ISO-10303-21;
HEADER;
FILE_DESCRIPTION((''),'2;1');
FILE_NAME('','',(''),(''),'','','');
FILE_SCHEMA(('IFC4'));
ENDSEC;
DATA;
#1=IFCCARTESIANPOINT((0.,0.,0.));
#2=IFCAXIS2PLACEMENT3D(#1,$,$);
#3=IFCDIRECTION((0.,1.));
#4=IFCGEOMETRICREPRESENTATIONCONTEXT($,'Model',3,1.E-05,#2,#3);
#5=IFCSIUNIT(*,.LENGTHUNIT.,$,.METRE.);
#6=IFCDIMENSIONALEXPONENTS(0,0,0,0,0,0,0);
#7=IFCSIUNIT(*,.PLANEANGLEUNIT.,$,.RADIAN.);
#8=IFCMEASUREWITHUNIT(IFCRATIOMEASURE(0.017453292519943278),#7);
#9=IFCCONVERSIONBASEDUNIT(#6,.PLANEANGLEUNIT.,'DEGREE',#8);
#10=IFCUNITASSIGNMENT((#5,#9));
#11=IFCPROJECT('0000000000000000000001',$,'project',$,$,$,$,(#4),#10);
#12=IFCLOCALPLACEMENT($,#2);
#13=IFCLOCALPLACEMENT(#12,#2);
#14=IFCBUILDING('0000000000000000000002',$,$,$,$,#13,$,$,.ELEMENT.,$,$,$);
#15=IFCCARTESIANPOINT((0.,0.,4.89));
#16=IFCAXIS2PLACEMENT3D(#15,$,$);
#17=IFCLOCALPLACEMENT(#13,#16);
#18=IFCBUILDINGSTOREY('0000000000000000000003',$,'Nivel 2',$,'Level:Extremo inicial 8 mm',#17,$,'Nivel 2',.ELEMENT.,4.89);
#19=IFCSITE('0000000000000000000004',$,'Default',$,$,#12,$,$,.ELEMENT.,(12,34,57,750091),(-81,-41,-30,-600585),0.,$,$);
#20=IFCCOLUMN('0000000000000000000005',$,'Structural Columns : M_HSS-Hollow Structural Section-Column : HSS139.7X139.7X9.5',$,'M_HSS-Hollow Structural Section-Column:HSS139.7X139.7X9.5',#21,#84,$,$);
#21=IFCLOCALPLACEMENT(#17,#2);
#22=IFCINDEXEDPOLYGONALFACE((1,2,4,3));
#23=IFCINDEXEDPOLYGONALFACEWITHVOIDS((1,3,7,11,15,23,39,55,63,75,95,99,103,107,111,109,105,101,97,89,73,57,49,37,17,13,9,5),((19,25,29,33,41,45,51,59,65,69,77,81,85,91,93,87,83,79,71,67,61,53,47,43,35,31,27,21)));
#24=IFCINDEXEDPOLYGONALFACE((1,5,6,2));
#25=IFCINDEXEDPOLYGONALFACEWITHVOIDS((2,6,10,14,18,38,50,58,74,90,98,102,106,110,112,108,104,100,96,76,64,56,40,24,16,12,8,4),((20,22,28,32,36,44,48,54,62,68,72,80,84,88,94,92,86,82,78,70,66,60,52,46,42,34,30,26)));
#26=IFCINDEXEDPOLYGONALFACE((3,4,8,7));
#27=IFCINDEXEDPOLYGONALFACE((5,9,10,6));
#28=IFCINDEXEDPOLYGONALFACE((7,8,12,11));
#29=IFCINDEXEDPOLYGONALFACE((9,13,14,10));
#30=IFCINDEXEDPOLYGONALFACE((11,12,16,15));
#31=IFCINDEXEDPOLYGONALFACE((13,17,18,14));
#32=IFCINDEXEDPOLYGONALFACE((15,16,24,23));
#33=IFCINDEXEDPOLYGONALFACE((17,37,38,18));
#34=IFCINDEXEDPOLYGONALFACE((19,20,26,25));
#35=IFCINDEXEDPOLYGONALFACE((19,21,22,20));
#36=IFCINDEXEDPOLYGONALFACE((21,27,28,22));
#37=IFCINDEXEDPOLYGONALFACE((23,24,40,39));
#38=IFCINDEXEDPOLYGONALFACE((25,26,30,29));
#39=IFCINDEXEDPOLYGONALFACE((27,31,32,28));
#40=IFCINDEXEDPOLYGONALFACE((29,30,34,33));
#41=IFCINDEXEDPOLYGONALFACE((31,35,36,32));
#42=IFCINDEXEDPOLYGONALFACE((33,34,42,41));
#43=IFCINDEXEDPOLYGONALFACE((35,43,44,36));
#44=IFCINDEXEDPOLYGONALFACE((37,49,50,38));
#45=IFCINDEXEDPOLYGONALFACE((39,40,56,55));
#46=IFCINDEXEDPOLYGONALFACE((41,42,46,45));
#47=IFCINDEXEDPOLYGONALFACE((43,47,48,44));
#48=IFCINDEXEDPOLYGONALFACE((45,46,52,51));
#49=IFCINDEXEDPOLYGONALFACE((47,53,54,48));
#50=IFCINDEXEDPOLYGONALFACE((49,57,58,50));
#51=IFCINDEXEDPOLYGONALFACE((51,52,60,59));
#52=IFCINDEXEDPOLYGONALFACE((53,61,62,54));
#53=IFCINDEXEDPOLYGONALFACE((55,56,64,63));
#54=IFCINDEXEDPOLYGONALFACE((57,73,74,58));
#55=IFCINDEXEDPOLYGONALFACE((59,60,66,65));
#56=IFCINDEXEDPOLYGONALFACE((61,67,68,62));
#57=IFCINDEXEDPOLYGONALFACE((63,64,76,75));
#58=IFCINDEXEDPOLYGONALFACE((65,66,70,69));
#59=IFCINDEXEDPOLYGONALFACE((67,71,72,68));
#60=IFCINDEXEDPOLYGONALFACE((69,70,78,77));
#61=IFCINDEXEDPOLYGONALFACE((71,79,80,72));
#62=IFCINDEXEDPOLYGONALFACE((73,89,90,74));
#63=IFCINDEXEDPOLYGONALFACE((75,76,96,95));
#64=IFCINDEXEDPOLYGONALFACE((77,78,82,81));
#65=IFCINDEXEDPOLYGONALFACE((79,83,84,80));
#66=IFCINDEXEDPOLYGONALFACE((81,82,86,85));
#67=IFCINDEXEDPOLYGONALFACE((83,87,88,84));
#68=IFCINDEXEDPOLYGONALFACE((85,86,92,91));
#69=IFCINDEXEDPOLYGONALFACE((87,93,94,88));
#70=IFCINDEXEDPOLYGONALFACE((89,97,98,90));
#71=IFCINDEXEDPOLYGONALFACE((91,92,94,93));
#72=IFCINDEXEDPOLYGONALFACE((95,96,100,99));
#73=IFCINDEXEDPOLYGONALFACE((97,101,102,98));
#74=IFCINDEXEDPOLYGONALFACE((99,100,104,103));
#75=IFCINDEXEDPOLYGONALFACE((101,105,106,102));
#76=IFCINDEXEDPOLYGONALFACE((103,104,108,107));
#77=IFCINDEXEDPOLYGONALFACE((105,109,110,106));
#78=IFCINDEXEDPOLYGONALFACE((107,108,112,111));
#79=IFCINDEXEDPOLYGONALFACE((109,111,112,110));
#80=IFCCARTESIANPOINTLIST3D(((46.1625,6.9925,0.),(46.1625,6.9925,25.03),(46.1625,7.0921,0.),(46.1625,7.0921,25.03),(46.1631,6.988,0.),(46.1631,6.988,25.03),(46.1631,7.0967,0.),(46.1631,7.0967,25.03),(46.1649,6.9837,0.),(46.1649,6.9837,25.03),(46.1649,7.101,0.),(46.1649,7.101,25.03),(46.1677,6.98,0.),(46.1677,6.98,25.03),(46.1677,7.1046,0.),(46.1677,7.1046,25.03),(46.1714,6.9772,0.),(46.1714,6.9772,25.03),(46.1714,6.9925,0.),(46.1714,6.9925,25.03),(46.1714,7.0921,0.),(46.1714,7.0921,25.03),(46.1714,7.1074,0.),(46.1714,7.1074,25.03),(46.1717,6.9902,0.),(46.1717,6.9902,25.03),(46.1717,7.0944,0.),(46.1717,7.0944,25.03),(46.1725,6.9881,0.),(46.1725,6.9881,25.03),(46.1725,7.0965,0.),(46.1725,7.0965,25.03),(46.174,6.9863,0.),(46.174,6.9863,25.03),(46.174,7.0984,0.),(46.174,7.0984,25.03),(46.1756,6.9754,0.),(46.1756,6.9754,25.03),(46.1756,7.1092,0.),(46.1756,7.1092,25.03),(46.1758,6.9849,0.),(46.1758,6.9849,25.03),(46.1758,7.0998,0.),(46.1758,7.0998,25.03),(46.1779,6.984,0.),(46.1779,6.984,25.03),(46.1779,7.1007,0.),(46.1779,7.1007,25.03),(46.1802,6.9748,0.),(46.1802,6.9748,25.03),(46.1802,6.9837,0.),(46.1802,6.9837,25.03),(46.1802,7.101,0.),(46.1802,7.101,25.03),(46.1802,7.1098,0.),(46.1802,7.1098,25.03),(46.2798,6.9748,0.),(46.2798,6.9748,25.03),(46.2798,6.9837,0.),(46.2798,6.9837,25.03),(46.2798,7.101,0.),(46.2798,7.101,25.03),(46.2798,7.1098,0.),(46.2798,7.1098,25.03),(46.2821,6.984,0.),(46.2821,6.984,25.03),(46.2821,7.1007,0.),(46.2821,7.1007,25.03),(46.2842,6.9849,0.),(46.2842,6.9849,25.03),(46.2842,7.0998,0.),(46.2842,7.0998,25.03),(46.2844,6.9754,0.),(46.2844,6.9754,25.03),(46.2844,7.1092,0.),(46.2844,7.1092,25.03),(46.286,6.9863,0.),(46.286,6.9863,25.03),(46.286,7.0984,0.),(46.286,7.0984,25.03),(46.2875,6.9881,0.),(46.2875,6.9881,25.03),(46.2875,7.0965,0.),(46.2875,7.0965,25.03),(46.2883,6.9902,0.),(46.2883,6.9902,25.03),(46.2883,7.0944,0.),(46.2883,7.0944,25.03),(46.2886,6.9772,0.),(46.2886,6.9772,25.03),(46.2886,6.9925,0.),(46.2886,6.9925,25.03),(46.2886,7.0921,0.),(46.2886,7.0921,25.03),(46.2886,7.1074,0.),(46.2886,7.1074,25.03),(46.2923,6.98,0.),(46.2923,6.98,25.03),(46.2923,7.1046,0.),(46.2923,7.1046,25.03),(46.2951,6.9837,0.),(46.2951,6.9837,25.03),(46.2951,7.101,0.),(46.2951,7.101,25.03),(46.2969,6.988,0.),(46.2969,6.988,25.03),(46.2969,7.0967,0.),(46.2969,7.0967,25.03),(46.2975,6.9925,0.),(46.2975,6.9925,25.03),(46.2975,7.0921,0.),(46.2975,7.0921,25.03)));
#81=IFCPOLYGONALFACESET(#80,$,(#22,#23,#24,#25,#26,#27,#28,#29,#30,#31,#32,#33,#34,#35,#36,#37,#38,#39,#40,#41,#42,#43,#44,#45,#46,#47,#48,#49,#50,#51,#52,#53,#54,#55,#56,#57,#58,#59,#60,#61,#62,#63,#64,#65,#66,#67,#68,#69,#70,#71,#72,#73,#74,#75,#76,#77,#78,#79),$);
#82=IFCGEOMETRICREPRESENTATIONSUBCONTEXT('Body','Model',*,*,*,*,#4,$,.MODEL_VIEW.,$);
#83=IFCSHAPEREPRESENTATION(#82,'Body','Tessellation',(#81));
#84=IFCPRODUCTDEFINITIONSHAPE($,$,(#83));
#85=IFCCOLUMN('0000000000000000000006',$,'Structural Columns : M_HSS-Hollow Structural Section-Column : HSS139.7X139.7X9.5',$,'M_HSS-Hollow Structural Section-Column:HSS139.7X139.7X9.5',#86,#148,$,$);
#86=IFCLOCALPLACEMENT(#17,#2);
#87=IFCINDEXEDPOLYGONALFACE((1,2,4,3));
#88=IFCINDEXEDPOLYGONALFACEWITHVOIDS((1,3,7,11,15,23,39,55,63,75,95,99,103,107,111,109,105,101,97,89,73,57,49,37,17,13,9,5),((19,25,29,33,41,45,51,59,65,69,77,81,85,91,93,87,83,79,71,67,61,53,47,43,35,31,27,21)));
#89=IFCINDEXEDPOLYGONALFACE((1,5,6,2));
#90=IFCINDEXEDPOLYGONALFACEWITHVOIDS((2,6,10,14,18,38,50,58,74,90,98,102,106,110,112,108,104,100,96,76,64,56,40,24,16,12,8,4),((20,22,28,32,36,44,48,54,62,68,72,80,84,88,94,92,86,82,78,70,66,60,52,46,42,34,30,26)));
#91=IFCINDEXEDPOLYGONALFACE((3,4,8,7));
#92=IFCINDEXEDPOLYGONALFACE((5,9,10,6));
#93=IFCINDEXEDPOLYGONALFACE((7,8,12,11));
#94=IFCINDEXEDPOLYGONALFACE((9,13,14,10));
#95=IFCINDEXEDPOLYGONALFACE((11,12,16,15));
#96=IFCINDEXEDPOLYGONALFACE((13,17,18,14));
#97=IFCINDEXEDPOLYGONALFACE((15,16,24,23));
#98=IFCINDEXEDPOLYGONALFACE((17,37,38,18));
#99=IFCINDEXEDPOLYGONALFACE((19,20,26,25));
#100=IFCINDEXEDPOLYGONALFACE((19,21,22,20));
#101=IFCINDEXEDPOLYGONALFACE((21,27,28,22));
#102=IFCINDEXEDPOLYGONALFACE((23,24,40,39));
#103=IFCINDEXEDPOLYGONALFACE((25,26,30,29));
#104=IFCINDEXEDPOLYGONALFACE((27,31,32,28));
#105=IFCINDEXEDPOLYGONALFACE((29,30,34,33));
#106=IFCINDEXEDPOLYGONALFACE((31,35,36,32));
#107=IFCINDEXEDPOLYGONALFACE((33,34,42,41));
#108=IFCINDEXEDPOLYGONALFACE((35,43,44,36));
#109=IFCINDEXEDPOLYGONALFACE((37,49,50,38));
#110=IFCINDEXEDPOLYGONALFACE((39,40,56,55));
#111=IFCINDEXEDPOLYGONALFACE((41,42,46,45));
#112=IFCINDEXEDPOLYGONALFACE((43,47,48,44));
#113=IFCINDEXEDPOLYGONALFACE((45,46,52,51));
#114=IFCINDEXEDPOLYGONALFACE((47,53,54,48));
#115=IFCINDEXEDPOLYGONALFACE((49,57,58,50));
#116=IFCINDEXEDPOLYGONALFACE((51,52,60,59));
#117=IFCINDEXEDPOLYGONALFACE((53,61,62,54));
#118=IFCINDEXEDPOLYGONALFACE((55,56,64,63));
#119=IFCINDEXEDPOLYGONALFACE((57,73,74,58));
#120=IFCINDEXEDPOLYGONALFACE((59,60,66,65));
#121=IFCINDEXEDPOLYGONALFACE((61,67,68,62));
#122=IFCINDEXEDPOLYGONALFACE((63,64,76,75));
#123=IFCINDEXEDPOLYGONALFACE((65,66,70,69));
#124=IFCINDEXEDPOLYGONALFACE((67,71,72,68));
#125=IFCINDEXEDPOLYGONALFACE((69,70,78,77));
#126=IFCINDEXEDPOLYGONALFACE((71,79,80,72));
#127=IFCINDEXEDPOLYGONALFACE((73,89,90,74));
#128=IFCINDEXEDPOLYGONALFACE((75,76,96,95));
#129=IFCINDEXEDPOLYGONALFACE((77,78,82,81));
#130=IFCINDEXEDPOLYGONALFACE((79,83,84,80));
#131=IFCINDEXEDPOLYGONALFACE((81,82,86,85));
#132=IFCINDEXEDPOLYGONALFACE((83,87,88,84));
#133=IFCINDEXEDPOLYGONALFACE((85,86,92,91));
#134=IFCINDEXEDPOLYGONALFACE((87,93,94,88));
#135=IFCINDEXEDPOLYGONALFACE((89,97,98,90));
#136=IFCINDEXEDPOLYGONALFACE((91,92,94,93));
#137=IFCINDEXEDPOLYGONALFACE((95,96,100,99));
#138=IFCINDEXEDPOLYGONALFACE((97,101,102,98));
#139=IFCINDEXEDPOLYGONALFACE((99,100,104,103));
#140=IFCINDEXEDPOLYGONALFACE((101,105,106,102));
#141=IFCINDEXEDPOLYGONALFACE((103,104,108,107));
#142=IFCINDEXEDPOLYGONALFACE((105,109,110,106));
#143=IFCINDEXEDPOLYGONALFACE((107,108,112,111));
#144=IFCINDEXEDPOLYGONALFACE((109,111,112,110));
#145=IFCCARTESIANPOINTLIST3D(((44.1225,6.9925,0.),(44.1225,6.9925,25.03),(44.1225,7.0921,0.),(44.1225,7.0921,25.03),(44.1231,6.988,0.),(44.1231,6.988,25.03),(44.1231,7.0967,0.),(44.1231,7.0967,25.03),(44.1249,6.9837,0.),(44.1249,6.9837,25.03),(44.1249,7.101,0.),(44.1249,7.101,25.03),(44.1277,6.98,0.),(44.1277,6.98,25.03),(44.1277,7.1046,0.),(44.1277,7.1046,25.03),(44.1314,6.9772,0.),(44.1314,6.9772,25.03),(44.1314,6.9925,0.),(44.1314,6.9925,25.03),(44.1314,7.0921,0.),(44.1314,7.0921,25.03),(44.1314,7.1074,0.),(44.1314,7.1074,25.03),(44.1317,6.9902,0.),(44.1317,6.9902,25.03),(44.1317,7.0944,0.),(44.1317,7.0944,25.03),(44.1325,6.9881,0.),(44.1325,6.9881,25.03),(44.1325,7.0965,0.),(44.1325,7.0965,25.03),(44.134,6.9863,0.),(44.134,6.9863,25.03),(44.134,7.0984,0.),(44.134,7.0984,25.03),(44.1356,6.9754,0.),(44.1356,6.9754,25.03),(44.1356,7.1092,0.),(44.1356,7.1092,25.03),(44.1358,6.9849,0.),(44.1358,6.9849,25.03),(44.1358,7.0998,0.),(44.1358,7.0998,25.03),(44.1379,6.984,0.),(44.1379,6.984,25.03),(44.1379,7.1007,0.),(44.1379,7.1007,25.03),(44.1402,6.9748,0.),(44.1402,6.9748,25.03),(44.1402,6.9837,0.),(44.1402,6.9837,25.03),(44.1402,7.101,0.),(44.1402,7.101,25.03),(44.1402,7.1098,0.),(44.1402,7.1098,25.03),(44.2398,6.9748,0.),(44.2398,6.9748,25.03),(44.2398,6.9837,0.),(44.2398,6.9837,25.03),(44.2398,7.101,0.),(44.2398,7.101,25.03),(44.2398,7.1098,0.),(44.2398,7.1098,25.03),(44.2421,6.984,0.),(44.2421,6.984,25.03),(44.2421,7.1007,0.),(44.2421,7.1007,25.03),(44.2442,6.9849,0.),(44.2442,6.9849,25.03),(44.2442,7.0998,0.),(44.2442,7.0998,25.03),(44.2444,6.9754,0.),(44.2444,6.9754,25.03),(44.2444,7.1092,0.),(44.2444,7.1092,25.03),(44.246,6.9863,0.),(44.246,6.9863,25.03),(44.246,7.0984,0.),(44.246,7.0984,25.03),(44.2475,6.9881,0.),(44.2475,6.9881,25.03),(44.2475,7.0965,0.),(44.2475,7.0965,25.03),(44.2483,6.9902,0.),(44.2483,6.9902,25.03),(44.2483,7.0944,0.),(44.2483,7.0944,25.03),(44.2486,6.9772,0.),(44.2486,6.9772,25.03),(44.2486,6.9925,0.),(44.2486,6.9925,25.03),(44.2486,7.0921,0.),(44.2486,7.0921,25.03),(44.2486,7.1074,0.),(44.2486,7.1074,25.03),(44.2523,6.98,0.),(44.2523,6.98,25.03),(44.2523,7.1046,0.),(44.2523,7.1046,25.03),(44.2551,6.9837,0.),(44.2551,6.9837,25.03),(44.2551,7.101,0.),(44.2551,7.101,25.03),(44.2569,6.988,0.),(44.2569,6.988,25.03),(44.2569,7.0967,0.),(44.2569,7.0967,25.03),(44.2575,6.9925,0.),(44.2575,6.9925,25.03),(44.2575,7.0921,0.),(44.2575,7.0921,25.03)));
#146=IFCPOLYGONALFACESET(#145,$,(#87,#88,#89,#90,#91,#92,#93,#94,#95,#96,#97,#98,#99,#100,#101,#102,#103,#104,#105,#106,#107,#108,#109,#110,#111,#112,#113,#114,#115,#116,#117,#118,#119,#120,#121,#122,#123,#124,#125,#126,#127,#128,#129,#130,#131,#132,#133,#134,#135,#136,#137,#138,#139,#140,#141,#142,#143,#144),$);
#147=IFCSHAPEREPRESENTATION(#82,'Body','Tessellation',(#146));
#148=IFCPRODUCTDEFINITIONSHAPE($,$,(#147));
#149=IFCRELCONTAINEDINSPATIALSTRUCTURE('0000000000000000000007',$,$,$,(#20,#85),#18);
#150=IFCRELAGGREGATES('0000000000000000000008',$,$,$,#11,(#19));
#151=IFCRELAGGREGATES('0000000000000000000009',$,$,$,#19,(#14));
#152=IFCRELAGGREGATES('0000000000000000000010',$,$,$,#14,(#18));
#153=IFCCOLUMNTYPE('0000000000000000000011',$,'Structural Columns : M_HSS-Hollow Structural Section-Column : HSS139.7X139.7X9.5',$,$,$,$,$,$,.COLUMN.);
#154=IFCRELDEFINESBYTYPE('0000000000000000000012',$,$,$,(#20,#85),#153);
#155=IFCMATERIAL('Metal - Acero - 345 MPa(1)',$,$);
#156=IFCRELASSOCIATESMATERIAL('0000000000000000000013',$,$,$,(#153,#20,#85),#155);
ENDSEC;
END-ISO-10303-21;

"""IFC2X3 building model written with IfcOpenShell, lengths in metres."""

from ifc_helpers import new_model, entity, si_unit, converted_unit, direction, frame, frame_2d, origin, place, context, subcontext, project, spatial, polyline, circle_curve, parameter, trimmed, segment, composite_curve, outline, extrude, source, transform, mapped, material, type_object, type_shapes, element, save


model = new_model("IFC2X3")

# Units and contexts
model_context = context("Model", 3, precision=1e-05, world=origin(), true_north=direction((0.0, 1.0)))
body_context = subcontext(model_context, "Body", "Model", "MODEL_VIEW")
ifc_project = project(units=[si_unit("LENGTHUNIT", "METRE"), converted_unit("PLANEANGLEUNIT", "DEGREE", entity("IfcRatioMeasure", 0.017453292519943278), si_unit("PLANEANGLEUNIT", "RADIAN"), dimensions=[0, 0, 0, 0, 0, 0, 0])], contexts=[model_context])

# Site, building, storey
site_placement = place(None, origin())
site = spatial("IfcSite", under=ifc_project, at=site_placement, Name="Default", CompositionType="ELEMENT", RefLatitude=(12, 34, 57, 750091), RefLongitude=(-81, -41, -30, -600585), RefElevation=0.0)
building_placement = place(site_placement, origin())
building = spatial("IfcBuilding", under=site, at=building_placement, CompositionType="ELEMENT")
storey_placement = place(building_placement, frame((0.0, 0.0, 4.89)))
storey = spatial("IfcBuildingStorey", under=building, at=storey_placement, Name="Nivel 2", ObjectType="Level:Extremo inicial 8 mm", LongName="Nivel 2", CompositionType="ELEMENT", Elevation=4.89)

# Columns
ifc_material_1 = material(Name="Metal - Acero - 345 MPa(1)")
column_type_1 = type_object("IfcColumnType", Name="Structural Columns : M_HSS-Hollow Structural Section-Column : HSS139.7X139.7X9.5", PredefinedType="COLUMN", material=ifc_material_1)
shared_shape_1 = source(origin(), body_context, "Body", "SweptSolid", [
    extrude(outline(composite_curve([segment(polyline([(-0.0498, -0.0675), (0.0498, -0.0675)]), True, "CONTINUOUS"), segment(trimmed(circle_curve(frame_2d((0.0498, -0.0498), x_axis=(-1.0, 0.0)), 0.0177), [parameter(90.0)], [parameter(180.0)], True, "PARAMETER"), True, "CONTINUOUS"), segment(polyline([(0.0675, -0.0498), (0.0675, 0.0498)]), True, "CONTINUOUS"), segment(trimmed(circle_curve(frame_2d((0.0498, 0.0498), x_axis=(-1.0, 0.0)), 0.0177), [parameter(180.0)], [parameter(270.0)], True, "PARAMETER"), True, "CONTINUOUS"), segment(polyline([(0.0498, 0.0675), (-0.0498, 0.0675)]), True, "CONTINUOUS"), segment(trimmed(circle_curve(frame_2d((-0.0498, 0.0498), x_axis=(-1.0, 0.0)), 0.0177), [parameter(270.0)], [parameter(360.0)], True, "PARAMETER"), True, "CONTINUOUS"), segment(polyline([(-0.0675, 0.0498), (-0.0675, -0.0498)]), True, "CONTINUOUS"), segment(trimmed(circle_curve(frame_2d((-0.0498, -0.0498), x_axis=(-1.0, 0.0)), 0.0177), [parameter(360.0)], [parameter(90.0)], True, "PARAMETER"), True, "CONTINUOUS")], self_intersect=False), holes=[composite_curve([segment(trimmed(circle_curve(frame_2d((-0.0498, -0.0498), x_axis=(-1.0, 0.0)), 0.0089), [parameter(0.0)], [parameter(90.0)], True, "PARAMETER"), False, "CONTINUOUS"), segment(polyline([(-0.0586, -0.0498), (-0.0586, 0.0498)]), True, "CONTINUOUS"), segment(trimmed(circle_curve(frame_2d((-0.0498, 0.0498), x_axis=(-1.0, 0.0)), 0.0089), [parameter(270.0)], [parameter(0.0)], True, "PARAMETER"), False, "CONTINUOUS"), segment(polyline([(-0.0498, 0.0586), (0.0498, 0.0586)]), True, "CONTINUOUS"), segment(trimmed(circle_curve(frame_2d((0.0498, 0.0498), x_axis=(-1.0, 0.0)), 0.0089), [parameter(180.0)], [parameter(270.0)], True, "PARAMETER"), False, "CONTINUOUS"), segment(polyline([(0.0586, 0.0498), (0.0586, -0.0498)]), True, "CONTINUOUS"), segment(trimmed(circle_curve(frame_2d((0.0498, -0.0498), x_axis=(-1.0, 0.0)), 0.0089), [parameter(90.0)], [parameter(180.0)], True, "PARAMETER"), False, "CONTINUOUS"), segment(polyline([(0.0498, -0.0586), (-0.0498, -0.0586)]), True, "CONTINUOUS")], self_intersect=False)]), frame((0.0, 0.0, 4.89), z_axis=(0.0, 0.0, 1.0), x_axis=(-1.0, 0.0, 0.0)), (0.0, 0.0, 1.0), 25.03),
])
type_shapes(column_type_1, [shared_shape_1])
for number, where, name in (
    (1, (46.23, 7.0423, -4.89), "Structural Columns : M_HSS-Hollow Structural Section-Column : HSS139.7X139.7X9.5"),
    (2, (44.19, 7.0423, -4.89), "Structural Columns : M_HSS-Hollow Structural Section-Column : HSS139.7X139.7X9.5"),
):
    element("IfcColumn", number, at=place(storey_placement, frame(where)), inside=storey, type_object=column_type_1, material=ifc_material_1, Name=name, ObjectType="M_HSS-Hollow Structural Section-Column:HSS139.7X139.7X9.5", context=body_context, shape_type="MappedRepresentation", body=[
        mapped(shared_shape_1, transform((0.0, 0.0, 0.0), scale=1.0)),
    ])

save(model, "model.ifc")
